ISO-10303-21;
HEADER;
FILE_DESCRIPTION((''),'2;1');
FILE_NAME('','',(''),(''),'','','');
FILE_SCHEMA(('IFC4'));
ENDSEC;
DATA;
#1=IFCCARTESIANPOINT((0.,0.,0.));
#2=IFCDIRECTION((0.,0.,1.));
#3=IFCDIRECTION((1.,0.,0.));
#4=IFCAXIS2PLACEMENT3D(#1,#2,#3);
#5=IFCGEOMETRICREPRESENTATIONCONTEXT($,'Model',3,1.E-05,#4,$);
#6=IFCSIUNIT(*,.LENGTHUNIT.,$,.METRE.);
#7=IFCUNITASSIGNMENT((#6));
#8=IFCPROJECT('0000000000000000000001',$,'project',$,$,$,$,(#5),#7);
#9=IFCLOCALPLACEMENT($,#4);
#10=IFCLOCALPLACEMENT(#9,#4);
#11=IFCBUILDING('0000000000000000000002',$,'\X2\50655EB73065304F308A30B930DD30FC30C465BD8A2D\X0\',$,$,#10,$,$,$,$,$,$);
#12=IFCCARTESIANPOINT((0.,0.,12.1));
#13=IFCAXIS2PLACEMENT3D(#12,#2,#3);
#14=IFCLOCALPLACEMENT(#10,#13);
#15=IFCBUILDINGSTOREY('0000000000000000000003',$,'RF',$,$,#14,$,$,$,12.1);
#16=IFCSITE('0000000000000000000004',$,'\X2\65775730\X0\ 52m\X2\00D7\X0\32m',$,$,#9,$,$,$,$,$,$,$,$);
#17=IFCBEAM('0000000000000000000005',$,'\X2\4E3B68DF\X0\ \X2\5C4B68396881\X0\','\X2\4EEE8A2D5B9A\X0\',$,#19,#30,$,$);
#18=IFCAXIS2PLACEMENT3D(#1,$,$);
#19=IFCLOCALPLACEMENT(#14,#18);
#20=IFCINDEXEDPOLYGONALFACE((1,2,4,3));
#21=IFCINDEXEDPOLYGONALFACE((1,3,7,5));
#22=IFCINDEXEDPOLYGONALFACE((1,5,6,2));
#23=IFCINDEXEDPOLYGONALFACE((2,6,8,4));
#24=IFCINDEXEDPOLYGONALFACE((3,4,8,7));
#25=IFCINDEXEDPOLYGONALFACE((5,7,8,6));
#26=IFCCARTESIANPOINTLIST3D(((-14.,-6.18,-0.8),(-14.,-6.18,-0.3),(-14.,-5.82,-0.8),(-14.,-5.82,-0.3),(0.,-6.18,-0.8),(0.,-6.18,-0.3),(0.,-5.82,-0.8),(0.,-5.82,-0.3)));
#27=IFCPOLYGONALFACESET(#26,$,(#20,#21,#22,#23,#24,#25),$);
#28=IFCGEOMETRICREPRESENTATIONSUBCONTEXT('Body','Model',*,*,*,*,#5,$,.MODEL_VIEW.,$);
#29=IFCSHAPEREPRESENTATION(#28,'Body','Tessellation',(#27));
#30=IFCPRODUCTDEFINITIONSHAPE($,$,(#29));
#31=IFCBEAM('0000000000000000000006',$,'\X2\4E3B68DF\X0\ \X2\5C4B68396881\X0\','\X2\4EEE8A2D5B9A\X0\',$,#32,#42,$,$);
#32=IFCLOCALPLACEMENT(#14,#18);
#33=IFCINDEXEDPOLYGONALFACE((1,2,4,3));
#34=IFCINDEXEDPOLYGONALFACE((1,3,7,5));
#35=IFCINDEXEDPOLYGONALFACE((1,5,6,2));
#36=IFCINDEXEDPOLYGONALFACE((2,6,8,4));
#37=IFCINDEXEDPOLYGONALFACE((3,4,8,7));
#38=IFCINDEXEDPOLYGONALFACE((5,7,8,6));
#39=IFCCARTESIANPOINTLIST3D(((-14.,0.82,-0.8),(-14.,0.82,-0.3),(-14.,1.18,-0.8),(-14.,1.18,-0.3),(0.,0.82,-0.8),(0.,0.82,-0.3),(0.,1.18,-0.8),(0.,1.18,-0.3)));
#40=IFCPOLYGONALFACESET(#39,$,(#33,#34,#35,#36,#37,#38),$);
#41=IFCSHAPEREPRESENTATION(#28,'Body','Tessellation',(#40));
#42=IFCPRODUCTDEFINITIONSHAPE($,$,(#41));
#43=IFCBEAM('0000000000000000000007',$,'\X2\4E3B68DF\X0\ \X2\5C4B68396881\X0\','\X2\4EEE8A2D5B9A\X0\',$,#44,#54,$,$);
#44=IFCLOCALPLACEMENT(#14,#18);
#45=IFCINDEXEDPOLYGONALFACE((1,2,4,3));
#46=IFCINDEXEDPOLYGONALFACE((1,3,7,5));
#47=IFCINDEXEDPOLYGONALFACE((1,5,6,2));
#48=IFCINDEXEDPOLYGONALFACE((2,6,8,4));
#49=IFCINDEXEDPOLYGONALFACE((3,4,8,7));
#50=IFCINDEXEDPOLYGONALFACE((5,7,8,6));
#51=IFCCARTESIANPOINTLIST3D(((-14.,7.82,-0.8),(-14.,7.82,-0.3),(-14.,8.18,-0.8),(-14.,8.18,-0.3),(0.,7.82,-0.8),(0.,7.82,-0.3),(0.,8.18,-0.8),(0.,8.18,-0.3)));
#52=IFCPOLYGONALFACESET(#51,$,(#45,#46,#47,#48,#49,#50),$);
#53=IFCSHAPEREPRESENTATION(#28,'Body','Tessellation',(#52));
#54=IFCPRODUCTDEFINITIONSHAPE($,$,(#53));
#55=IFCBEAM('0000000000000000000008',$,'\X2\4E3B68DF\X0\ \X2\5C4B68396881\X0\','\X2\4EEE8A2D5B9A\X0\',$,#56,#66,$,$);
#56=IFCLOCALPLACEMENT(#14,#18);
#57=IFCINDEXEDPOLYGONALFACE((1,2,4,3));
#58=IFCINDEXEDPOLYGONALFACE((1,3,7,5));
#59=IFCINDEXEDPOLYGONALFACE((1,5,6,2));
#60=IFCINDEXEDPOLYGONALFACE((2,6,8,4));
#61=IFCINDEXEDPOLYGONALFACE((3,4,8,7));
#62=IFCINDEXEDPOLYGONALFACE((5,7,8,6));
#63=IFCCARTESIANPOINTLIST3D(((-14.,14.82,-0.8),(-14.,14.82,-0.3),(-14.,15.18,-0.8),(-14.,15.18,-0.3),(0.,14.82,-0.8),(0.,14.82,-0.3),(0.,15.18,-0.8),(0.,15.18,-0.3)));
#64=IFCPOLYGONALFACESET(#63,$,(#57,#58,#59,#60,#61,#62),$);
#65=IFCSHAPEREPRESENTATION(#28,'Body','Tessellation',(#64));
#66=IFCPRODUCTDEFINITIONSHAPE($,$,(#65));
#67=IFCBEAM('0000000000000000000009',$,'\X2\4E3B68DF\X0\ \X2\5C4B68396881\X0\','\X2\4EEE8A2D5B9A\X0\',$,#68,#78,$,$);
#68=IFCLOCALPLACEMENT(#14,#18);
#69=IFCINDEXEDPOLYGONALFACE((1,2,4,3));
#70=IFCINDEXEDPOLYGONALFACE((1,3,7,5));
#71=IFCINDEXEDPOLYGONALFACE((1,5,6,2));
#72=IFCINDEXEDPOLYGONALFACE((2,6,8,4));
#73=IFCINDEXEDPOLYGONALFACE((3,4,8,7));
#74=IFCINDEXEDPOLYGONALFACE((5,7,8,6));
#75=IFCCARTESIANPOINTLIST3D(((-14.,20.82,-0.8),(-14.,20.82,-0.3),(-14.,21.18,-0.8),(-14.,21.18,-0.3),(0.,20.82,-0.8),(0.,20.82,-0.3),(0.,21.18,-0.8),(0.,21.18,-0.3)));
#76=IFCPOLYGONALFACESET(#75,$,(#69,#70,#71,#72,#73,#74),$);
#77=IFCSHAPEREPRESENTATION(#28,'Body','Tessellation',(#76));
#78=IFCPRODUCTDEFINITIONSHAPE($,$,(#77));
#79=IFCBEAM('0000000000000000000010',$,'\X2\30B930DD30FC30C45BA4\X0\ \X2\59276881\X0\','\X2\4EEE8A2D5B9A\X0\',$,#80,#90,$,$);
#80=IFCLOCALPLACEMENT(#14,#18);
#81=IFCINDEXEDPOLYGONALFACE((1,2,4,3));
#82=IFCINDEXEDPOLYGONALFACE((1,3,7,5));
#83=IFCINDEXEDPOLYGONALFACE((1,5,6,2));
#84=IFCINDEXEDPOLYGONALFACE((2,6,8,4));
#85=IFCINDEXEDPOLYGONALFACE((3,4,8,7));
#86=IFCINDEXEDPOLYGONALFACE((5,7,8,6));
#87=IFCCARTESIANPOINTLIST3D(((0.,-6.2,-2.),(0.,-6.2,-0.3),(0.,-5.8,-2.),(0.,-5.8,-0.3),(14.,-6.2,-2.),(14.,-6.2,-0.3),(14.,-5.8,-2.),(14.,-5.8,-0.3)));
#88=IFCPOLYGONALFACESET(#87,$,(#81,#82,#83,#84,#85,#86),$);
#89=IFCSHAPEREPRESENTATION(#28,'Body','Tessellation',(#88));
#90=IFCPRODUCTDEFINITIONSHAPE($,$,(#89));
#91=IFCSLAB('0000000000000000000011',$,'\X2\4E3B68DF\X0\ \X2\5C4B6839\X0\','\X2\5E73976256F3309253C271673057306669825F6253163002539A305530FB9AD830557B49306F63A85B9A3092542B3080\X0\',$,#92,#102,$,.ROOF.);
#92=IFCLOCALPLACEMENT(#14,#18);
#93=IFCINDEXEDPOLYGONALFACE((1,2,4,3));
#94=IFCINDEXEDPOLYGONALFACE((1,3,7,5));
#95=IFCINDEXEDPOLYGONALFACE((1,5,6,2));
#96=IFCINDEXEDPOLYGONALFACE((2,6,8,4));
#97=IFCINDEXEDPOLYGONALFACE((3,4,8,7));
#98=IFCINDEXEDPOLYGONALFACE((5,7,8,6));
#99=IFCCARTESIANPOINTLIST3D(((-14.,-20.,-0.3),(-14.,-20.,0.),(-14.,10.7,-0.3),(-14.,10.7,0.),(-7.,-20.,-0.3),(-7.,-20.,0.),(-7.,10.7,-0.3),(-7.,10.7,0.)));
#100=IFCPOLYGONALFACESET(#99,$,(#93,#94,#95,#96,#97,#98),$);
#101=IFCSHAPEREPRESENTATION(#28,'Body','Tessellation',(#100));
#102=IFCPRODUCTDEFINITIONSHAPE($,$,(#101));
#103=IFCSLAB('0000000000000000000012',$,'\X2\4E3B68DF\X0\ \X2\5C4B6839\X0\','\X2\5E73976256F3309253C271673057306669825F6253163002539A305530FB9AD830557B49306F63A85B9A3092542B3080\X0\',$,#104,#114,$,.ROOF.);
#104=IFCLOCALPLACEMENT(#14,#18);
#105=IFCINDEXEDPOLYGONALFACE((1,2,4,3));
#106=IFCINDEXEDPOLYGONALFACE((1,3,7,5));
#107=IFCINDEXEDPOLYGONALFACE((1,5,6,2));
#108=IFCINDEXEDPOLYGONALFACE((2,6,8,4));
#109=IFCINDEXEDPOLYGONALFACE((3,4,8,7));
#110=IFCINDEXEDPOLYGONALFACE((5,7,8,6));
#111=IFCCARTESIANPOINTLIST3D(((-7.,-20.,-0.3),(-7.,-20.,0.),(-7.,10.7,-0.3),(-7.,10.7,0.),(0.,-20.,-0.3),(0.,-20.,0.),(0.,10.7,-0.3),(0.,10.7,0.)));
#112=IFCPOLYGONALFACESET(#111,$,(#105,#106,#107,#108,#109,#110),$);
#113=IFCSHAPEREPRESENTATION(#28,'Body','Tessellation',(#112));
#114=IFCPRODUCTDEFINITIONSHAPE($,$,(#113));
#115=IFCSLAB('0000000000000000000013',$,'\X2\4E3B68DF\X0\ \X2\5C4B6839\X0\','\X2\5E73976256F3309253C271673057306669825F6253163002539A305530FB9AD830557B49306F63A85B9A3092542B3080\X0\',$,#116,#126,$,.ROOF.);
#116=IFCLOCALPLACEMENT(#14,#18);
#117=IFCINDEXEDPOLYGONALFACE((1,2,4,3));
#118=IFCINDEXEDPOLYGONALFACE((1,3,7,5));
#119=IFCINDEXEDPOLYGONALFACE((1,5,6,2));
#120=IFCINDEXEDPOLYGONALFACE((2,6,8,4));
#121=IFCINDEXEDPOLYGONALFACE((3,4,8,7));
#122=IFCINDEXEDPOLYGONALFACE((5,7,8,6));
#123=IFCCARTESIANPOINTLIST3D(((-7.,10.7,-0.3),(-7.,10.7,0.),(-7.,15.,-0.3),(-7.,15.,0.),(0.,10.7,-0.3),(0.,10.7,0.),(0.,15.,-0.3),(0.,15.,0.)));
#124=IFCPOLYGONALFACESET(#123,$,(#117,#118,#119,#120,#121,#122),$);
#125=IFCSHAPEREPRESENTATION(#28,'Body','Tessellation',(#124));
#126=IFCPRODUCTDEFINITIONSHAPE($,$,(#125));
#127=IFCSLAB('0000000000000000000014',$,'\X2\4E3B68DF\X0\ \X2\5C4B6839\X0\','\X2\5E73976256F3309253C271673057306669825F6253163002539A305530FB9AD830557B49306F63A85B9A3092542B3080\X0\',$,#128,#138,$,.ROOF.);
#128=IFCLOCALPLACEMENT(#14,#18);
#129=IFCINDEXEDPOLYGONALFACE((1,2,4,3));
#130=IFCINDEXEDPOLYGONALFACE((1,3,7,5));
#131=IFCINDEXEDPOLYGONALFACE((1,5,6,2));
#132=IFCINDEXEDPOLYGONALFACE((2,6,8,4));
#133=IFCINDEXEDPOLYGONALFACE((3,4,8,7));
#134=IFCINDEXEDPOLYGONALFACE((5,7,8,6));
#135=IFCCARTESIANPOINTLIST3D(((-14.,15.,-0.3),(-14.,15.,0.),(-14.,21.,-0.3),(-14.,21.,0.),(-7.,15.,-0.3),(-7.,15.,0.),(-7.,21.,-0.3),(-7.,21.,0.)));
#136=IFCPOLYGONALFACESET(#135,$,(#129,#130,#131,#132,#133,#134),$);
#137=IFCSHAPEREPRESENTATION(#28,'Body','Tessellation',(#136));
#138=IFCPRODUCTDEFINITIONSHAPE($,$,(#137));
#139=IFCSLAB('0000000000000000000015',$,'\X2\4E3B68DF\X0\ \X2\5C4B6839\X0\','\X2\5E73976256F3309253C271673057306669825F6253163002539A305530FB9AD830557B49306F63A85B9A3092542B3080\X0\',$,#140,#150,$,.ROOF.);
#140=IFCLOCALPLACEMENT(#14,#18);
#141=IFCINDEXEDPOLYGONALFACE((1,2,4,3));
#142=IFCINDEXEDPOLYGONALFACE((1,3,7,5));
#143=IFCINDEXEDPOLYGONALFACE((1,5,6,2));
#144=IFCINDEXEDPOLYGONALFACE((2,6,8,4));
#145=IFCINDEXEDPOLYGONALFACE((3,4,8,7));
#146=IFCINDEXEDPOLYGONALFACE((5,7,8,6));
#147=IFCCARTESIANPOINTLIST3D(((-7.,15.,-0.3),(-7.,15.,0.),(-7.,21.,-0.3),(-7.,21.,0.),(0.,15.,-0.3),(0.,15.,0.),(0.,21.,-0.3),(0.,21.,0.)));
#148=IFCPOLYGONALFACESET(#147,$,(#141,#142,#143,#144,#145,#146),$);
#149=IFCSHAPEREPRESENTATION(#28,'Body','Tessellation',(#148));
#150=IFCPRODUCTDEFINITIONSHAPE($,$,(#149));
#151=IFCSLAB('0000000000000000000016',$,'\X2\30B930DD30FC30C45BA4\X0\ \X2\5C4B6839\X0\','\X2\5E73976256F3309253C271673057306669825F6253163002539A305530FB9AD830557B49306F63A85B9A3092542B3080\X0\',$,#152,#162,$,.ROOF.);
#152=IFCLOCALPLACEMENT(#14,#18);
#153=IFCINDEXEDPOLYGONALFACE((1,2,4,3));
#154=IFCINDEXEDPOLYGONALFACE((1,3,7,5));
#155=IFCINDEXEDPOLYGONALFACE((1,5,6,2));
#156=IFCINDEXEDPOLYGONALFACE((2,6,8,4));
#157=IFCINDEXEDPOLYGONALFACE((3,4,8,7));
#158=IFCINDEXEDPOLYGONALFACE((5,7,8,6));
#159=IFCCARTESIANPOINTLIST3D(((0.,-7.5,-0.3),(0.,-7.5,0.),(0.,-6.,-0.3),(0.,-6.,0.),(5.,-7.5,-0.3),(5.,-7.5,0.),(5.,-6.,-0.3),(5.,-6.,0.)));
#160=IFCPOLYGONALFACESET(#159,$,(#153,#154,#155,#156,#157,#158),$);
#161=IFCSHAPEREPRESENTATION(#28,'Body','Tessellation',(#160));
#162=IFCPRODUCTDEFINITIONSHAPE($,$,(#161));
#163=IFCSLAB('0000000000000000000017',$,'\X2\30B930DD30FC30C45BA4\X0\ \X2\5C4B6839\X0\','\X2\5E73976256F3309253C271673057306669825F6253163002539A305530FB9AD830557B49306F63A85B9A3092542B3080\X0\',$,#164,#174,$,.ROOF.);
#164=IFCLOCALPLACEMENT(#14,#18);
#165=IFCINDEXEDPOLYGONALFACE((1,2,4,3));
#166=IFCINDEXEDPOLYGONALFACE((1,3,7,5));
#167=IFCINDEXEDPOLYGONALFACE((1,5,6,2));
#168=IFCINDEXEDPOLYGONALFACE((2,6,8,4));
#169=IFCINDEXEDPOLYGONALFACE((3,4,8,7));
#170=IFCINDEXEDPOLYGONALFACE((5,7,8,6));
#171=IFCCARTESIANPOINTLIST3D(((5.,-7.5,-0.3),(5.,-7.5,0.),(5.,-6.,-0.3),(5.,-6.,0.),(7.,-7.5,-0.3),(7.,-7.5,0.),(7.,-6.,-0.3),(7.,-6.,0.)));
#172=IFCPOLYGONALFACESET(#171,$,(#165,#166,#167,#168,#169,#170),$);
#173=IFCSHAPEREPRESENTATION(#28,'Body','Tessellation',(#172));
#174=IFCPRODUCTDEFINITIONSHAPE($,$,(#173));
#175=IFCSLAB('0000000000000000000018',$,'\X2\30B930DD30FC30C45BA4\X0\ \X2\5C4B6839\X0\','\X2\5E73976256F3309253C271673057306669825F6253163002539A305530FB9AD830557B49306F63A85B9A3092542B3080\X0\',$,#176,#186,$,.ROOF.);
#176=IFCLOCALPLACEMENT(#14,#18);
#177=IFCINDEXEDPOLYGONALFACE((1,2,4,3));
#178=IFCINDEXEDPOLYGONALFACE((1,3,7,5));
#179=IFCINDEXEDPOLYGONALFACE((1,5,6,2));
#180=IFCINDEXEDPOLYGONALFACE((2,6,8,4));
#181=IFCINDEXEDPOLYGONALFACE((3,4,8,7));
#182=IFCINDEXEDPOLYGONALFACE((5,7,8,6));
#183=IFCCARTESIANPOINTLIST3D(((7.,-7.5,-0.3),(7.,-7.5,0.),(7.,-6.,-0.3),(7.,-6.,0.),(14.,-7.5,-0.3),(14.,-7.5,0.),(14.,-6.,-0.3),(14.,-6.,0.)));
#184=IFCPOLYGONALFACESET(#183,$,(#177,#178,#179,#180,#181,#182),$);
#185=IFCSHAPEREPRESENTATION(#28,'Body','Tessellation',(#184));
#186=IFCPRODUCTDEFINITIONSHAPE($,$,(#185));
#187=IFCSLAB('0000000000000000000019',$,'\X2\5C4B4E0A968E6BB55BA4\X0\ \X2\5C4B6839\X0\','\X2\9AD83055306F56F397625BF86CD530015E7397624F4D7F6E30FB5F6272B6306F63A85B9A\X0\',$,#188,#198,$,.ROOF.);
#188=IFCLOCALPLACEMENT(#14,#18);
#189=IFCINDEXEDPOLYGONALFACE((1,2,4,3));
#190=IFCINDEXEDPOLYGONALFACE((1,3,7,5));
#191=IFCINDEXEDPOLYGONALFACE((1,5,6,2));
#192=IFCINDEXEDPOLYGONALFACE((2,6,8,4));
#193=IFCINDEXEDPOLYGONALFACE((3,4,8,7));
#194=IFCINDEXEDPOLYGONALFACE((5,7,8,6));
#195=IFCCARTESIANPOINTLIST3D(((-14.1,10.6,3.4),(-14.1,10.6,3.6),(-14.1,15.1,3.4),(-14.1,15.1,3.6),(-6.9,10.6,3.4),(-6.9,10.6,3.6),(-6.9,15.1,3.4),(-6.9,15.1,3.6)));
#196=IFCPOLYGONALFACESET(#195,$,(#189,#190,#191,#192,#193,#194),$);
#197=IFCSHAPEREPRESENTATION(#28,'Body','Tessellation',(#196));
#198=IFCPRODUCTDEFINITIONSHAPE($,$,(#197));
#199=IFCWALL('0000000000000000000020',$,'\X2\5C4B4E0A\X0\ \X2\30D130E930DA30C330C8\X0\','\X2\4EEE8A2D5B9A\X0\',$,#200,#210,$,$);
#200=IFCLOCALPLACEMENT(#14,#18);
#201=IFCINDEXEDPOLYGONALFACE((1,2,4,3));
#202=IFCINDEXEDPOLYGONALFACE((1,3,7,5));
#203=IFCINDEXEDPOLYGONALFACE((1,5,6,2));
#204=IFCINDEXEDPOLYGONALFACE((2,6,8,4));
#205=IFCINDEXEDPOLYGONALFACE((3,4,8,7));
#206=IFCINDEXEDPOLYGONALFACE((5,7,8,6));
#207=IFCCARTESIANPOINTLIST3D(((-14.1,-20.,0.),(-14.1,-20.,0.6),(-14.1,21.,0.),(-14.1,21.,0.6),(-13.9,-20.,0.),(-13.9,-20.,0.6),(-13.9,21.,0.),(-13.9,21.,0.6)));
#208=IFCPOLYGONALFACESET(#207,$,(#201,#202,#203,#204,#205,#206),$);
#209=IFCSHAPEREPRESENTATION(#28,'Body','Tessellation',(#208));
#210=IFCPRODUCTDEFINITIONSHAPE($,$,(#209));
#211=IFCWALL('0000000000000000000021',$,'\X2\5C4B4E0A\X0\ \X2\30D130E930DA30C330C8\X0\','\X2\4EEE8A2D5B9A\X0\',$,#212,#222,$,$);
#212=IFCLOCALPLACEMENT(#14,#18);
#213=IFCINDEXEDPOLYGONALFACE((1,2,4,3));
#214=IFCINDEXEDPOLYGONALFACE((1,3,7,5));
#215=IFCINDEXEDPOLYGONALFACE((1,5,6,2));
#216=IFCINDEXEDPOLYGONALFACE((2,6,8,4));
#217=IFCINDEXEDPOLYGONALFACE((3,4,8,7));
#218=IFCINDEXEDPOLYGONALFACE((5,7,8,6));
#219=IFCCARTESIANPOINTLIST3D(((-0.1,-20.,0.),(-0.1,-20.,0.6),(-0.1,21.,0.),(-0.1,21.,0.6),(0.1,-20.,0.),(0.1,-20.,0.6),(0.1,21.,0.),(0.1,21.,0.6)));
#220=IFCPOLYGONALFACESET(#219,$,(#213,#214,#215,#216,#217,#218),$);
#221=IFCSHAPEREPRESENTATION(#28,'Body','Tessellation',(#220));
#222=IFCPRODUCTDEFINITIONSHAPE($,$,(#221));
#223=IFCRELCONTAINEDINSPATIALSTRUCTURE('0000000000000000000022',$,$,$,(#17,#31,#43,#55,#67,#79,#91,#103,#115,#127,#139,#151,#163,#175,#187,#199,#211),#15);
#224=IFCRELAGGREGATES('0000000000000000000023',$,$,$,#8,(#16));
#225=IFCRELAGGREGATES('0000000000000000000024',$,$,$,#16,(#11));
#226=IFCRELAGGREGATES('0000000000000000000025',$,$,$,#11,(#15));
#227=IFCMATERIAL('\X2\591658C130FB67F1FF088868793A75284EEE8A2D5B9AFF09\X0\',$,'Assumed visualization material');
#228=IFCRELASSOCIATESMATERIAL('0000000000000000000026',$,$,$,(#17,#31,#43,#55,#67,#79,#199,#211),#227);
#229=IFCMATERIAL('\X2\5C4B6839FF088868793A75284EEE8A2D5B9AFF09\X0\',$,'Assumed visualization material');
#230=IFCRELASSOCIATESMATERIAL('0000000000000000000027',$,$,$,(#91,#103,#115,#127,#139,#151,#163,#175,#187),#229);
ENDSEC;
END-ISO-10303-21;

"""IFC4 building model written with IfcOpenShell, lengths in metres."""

from ifc_helpers import new_model, si_unit, frame, origin_with_axes, place, context, subcontext, project, spatial, rectangle, extrude, material, element, save


model = new_model("IFC4")

# Units and contexts
model_context = context("Model", 3, precision=1e-05, world=origin_with_axes())
body_context = subcontext(model_context, "Body", "Model", "MODEL_VIEW")
ifc_project = project(units=[si_unit("LENGTHUNIT", "METRE")], contexts=[model_context])

# Site, building, storey
site_placement = place(None, origin_with_axes())
site = spatial("IfcSite", under=ifc_project, at=site_placement, Name="敷地 52m×32m")
building_placement = place(site_placement, origin_with_axes())
building = spatial("IfcBuilding", under=site, at=building_placement, Name="健康づくりスポーツ施設")
storey_placement = place(building_placement, frame((0.0, 0.0, 12.1), z_axis=(0.0, 0.0, 1.0), x_axis=(1.0, 0.0, 0.0)))
storey = spatial("IfcBuildingStorey", under=building, at=storey_placement, Name="RF", Elevation=12.1)

# Beams
ifc_material_1 = material(Name="外壁・柱（表示用仮設定）", Category="Assumed visualization material")
for number, where, z_axis, x_axis, name in (
    (1, (-7.0, -6.0, -0.8), (0.0, 0.0, 1.0), (1.0, 0.0, 0.0), "主棟 屋根梁"),
    (2, (-7.0, 1.0, -0.8), (0.0, 0.0, 1.0), (1.0, 0.0, 0.0), "主棟 屋根梁"),
    (3, (-7.0, 8.0, -0.8), (0.0, 0.0, 1.0), (1.0, 0.0, 0.0), "主棟 屋根梁"),
    (4, (-7.0, 15.0, -0.8), (0.0, 0.0, 1.0), (1.0, 0.0, 0.0), "主棟 屋根梁"),
    (5, (-7.0, 21.0, -0.8), (0.0, 0.0, 1.0), (1.0, 0.0, 0.0), "主棟 屋根梁"),
):
    element("IfcBeam", number, at=place(storey_placement, frame(where, z_axis=z_axis, x_axis=x_axis)), inside=storey, material=ifc_material_1, Name=name, Description="仮設定", context=body_context, shape_type="SweptSolid", body=[
        extrude(rectangle(XDim=14.0, YDim=0.36), origin_with_axes(), (0.0, 0.0, 1.0), 0.5),
    ])
beam_placement = place(storey_placement, frame((7.0, -6.0, -2.0), z_axis=(0.0, 0.0, 1.0), x_axis=(1.0, 0.0, 0.0)))
element("IfcBeam", 6, at=beam_placement, inside=storey, material=ifc_material_1, Name="スポーツ室 大梁", Description="仮設定", context=body_context, shape_type="SweptSolid", body=[
    extrude(rectangle(XDim=14.0, YDim=0.4), origin_with_axes(), (0.0, 0.0, 1.0), 1.7),
])

# Slabs
ifc_material_2 = material(Name="屋根（表示用仮設定）", Category="Assumed visualization material")
for number, where, z_axis, x_axis, name in (
    (7, (-10.5, -4.65, -0.3), (0.0, 0.0, 1.0), (1.0, 0.0, 0.0), "主棟 屋根"),
    (8, (-3.5, -4.65, -0.3), (0.0, 0.0, 1.0), (1.0, 0.0, 0.0), "主棟 屋根"),
):
    element("IfcSlab", number, at=place(storey_placement, frame(where, z_axis=z_axis, x_axis=x_axis)), inside=storey, material=ifc_material_2, Name=name, Description="平面図を参照して概形化。厚さ・高さ等は推定を含む", PredefinedType="ROOF", context=body_context, shape_type="SweptSolid", body=[
        extrude(rectangle(XDim=7.0, YDim=30.7), origin_with_axes(), (0.0, 0.0, 1.0), 0.3),
    ])
slab_1_placement = place(storey_placement, frame((-3.5, 12.85, -0.3), z_axis=(0.0, 0.0, 1.0), x_axis=(1.0, 0.0, 0.0)))
element("IfcSlab", 9, at=slab_1_placement, inside=storey, material=ifc_material_2, Name="主棟 屋根", Description="平面図を参照して概形化。厚さ・高さ等は推定を含む", PredefinedType="ROOF", context=body_context, shape_type="SweptSolid", body=[
    extrude(rectangle(XDim=7.0, YDim=4.3), origin_with_axes(), (0.0, 0.0, 1.0), 0.3),
])
for number, where, z_axis, x_axis, name in (
    (10, (-10.5, 18.0, -0.3), (0.0, 0.0, 1.0), (1.0, 0.0, 0.0), "主棟 屋根"),
    (11, (-3.5, 18.0, -0.3), (0.0, 0.0, 1.0), (1.0, 0.0, 0.0), "主棟 屋根"),
):
    element("IfcSlab", number, at=place(storey_placement, frame(where, z_axis=z_axis, x_axis=x_axis)), inside=storey, material=ifc_material_2, Name=name, Description="平面図を参照して概形化。厚さ・高さ等は推定を含む", PredefinedType="ROOF", context=body_context, shape_type="SweptSolid", body=[
        extrude(rectangle(XDim=7.0, YDim=6.0), origin_with_axes(), (0.0, 0.0, 1.0), 0.3),
    ])
slab_2_placement = place(storey_placement, frame((2.5, -6.75, -0.3), z_axis=(0.0, 0.0, 1.0), x_axis=(1.0, 0.0, 0.0)))
element("IfcSlab", 12, at=slab_2_placement, inside=storey, material=ifc_material_2, Name="スポーツ室 屋根", Description="平面図を参照して概形化。厚さ・高さ等は推定を含む", PredefinedType="ROOF", context=body_context, shape_type="SweptSolid", body=[
    extrude(rectangle(XDim=5.0, YDim=1.5), origin_with_axes(), (0.0, 0.0, 1.0), 0.3),
])
slab_3_placement = place(storey_placement, frame((6.0, -6.75, -0.3), z_axis=(0.0, 0.0, 1.0), x_axis=(1.0, 0.0, 0.0)))
element("IfcSlab", 13, at=slab_3_placement, inside=storey, material=ifc_material_2, Name="スポーツ室 屋根", Description="平面図を参照して概形化。厚さ・高さ等は推定を含む", PredefinedType="ROOF", context=body_context, shape_type="SweptSolid", body=[
    extrude(rectangle(XDim=2.0, YDim=1.5), origin_with_axes(), (0.0, 0.0, 1.0), 0.3),
])
slab_4_placement = place(storey_placement, frame((10.5, -6.75, -0.3), z_axis=(0.0, 0.0, 1.0), x_axis=(1.0, 0.0, 0.0)))
element("IfcSlab", 14, at=slab_4_placement, inside=storey, material=ifc_material_2, Name="スポーツ室 屋根", Description="平面図を参照して概形化。厚さ・高さ等は推定を含む", PredefinedType="ROOF", context=body_context, shape_type="SweptSolid", body=[
    extrude(rectangle(XDim=7.0, YDim=1.5), origin_with_axes(), (0.0, 0.0, 1.0), 0.3),
])
slab_5_placement = place(storey_placement, frame((-10.5, 12.85, 3.4), z_axis=(0.0, 0.0, 1.0), x_axis=(1.0, 0.0, 0.0)))
element("IfcSlab", 15, at=slab_5_placement, inside=storey, material=ifc_material_2, Name="屋上階段室 屋根", Description="高さは図面寸法、平面位置・形状は推定", PredefinedType="ROOF", context=body_context, shape_type="SweptSolid", body=[
    extrude(rectangle(XDim=7.2, YDim=4.5), origin_with_axes(), (0.0, 0.0, 1.0), 0.2),
])

# Walls
wall_1_placement = place(storey_placement, frame((-14.0, 0.5, 0.0), z_axis=(0.0, 0.0, 1.0), x_axis=(1.0, 0.0, 0.0)))
element("IfcWall", 16, at=wall_1_placement, inside=storey, material=ifc_material_1, Name="屋上 パラペット", Description="仮設定", context=body_context, shape_type="SweptSolid", body=[
    extrude(rectangle(XDim=0.2, YDim=41.0), origin_with_axes(), (0.0, 0.0, 1.0), 0.6),
])
wall_2_placement = place(storey_placement, frame((0.0, 0.5, 0.0), z_axis=(0.0, 0.0, 1.0), x_axis=(1.0, 0.0, 0.0)))
element("IfcWall", 17, at=wall_2_placement, inside=storey, material=ifc_material_1, Name="屋上 パラペット", Description="仮設定", context=body_context, shape_type="SweptSolid", body=[
    extrude(rectangle(XDim=0.2, YDim=41.0), origin_with_axes(), (0.0, 0.0, 1.0), 0.6),
])

save(model, "model.ifc")
